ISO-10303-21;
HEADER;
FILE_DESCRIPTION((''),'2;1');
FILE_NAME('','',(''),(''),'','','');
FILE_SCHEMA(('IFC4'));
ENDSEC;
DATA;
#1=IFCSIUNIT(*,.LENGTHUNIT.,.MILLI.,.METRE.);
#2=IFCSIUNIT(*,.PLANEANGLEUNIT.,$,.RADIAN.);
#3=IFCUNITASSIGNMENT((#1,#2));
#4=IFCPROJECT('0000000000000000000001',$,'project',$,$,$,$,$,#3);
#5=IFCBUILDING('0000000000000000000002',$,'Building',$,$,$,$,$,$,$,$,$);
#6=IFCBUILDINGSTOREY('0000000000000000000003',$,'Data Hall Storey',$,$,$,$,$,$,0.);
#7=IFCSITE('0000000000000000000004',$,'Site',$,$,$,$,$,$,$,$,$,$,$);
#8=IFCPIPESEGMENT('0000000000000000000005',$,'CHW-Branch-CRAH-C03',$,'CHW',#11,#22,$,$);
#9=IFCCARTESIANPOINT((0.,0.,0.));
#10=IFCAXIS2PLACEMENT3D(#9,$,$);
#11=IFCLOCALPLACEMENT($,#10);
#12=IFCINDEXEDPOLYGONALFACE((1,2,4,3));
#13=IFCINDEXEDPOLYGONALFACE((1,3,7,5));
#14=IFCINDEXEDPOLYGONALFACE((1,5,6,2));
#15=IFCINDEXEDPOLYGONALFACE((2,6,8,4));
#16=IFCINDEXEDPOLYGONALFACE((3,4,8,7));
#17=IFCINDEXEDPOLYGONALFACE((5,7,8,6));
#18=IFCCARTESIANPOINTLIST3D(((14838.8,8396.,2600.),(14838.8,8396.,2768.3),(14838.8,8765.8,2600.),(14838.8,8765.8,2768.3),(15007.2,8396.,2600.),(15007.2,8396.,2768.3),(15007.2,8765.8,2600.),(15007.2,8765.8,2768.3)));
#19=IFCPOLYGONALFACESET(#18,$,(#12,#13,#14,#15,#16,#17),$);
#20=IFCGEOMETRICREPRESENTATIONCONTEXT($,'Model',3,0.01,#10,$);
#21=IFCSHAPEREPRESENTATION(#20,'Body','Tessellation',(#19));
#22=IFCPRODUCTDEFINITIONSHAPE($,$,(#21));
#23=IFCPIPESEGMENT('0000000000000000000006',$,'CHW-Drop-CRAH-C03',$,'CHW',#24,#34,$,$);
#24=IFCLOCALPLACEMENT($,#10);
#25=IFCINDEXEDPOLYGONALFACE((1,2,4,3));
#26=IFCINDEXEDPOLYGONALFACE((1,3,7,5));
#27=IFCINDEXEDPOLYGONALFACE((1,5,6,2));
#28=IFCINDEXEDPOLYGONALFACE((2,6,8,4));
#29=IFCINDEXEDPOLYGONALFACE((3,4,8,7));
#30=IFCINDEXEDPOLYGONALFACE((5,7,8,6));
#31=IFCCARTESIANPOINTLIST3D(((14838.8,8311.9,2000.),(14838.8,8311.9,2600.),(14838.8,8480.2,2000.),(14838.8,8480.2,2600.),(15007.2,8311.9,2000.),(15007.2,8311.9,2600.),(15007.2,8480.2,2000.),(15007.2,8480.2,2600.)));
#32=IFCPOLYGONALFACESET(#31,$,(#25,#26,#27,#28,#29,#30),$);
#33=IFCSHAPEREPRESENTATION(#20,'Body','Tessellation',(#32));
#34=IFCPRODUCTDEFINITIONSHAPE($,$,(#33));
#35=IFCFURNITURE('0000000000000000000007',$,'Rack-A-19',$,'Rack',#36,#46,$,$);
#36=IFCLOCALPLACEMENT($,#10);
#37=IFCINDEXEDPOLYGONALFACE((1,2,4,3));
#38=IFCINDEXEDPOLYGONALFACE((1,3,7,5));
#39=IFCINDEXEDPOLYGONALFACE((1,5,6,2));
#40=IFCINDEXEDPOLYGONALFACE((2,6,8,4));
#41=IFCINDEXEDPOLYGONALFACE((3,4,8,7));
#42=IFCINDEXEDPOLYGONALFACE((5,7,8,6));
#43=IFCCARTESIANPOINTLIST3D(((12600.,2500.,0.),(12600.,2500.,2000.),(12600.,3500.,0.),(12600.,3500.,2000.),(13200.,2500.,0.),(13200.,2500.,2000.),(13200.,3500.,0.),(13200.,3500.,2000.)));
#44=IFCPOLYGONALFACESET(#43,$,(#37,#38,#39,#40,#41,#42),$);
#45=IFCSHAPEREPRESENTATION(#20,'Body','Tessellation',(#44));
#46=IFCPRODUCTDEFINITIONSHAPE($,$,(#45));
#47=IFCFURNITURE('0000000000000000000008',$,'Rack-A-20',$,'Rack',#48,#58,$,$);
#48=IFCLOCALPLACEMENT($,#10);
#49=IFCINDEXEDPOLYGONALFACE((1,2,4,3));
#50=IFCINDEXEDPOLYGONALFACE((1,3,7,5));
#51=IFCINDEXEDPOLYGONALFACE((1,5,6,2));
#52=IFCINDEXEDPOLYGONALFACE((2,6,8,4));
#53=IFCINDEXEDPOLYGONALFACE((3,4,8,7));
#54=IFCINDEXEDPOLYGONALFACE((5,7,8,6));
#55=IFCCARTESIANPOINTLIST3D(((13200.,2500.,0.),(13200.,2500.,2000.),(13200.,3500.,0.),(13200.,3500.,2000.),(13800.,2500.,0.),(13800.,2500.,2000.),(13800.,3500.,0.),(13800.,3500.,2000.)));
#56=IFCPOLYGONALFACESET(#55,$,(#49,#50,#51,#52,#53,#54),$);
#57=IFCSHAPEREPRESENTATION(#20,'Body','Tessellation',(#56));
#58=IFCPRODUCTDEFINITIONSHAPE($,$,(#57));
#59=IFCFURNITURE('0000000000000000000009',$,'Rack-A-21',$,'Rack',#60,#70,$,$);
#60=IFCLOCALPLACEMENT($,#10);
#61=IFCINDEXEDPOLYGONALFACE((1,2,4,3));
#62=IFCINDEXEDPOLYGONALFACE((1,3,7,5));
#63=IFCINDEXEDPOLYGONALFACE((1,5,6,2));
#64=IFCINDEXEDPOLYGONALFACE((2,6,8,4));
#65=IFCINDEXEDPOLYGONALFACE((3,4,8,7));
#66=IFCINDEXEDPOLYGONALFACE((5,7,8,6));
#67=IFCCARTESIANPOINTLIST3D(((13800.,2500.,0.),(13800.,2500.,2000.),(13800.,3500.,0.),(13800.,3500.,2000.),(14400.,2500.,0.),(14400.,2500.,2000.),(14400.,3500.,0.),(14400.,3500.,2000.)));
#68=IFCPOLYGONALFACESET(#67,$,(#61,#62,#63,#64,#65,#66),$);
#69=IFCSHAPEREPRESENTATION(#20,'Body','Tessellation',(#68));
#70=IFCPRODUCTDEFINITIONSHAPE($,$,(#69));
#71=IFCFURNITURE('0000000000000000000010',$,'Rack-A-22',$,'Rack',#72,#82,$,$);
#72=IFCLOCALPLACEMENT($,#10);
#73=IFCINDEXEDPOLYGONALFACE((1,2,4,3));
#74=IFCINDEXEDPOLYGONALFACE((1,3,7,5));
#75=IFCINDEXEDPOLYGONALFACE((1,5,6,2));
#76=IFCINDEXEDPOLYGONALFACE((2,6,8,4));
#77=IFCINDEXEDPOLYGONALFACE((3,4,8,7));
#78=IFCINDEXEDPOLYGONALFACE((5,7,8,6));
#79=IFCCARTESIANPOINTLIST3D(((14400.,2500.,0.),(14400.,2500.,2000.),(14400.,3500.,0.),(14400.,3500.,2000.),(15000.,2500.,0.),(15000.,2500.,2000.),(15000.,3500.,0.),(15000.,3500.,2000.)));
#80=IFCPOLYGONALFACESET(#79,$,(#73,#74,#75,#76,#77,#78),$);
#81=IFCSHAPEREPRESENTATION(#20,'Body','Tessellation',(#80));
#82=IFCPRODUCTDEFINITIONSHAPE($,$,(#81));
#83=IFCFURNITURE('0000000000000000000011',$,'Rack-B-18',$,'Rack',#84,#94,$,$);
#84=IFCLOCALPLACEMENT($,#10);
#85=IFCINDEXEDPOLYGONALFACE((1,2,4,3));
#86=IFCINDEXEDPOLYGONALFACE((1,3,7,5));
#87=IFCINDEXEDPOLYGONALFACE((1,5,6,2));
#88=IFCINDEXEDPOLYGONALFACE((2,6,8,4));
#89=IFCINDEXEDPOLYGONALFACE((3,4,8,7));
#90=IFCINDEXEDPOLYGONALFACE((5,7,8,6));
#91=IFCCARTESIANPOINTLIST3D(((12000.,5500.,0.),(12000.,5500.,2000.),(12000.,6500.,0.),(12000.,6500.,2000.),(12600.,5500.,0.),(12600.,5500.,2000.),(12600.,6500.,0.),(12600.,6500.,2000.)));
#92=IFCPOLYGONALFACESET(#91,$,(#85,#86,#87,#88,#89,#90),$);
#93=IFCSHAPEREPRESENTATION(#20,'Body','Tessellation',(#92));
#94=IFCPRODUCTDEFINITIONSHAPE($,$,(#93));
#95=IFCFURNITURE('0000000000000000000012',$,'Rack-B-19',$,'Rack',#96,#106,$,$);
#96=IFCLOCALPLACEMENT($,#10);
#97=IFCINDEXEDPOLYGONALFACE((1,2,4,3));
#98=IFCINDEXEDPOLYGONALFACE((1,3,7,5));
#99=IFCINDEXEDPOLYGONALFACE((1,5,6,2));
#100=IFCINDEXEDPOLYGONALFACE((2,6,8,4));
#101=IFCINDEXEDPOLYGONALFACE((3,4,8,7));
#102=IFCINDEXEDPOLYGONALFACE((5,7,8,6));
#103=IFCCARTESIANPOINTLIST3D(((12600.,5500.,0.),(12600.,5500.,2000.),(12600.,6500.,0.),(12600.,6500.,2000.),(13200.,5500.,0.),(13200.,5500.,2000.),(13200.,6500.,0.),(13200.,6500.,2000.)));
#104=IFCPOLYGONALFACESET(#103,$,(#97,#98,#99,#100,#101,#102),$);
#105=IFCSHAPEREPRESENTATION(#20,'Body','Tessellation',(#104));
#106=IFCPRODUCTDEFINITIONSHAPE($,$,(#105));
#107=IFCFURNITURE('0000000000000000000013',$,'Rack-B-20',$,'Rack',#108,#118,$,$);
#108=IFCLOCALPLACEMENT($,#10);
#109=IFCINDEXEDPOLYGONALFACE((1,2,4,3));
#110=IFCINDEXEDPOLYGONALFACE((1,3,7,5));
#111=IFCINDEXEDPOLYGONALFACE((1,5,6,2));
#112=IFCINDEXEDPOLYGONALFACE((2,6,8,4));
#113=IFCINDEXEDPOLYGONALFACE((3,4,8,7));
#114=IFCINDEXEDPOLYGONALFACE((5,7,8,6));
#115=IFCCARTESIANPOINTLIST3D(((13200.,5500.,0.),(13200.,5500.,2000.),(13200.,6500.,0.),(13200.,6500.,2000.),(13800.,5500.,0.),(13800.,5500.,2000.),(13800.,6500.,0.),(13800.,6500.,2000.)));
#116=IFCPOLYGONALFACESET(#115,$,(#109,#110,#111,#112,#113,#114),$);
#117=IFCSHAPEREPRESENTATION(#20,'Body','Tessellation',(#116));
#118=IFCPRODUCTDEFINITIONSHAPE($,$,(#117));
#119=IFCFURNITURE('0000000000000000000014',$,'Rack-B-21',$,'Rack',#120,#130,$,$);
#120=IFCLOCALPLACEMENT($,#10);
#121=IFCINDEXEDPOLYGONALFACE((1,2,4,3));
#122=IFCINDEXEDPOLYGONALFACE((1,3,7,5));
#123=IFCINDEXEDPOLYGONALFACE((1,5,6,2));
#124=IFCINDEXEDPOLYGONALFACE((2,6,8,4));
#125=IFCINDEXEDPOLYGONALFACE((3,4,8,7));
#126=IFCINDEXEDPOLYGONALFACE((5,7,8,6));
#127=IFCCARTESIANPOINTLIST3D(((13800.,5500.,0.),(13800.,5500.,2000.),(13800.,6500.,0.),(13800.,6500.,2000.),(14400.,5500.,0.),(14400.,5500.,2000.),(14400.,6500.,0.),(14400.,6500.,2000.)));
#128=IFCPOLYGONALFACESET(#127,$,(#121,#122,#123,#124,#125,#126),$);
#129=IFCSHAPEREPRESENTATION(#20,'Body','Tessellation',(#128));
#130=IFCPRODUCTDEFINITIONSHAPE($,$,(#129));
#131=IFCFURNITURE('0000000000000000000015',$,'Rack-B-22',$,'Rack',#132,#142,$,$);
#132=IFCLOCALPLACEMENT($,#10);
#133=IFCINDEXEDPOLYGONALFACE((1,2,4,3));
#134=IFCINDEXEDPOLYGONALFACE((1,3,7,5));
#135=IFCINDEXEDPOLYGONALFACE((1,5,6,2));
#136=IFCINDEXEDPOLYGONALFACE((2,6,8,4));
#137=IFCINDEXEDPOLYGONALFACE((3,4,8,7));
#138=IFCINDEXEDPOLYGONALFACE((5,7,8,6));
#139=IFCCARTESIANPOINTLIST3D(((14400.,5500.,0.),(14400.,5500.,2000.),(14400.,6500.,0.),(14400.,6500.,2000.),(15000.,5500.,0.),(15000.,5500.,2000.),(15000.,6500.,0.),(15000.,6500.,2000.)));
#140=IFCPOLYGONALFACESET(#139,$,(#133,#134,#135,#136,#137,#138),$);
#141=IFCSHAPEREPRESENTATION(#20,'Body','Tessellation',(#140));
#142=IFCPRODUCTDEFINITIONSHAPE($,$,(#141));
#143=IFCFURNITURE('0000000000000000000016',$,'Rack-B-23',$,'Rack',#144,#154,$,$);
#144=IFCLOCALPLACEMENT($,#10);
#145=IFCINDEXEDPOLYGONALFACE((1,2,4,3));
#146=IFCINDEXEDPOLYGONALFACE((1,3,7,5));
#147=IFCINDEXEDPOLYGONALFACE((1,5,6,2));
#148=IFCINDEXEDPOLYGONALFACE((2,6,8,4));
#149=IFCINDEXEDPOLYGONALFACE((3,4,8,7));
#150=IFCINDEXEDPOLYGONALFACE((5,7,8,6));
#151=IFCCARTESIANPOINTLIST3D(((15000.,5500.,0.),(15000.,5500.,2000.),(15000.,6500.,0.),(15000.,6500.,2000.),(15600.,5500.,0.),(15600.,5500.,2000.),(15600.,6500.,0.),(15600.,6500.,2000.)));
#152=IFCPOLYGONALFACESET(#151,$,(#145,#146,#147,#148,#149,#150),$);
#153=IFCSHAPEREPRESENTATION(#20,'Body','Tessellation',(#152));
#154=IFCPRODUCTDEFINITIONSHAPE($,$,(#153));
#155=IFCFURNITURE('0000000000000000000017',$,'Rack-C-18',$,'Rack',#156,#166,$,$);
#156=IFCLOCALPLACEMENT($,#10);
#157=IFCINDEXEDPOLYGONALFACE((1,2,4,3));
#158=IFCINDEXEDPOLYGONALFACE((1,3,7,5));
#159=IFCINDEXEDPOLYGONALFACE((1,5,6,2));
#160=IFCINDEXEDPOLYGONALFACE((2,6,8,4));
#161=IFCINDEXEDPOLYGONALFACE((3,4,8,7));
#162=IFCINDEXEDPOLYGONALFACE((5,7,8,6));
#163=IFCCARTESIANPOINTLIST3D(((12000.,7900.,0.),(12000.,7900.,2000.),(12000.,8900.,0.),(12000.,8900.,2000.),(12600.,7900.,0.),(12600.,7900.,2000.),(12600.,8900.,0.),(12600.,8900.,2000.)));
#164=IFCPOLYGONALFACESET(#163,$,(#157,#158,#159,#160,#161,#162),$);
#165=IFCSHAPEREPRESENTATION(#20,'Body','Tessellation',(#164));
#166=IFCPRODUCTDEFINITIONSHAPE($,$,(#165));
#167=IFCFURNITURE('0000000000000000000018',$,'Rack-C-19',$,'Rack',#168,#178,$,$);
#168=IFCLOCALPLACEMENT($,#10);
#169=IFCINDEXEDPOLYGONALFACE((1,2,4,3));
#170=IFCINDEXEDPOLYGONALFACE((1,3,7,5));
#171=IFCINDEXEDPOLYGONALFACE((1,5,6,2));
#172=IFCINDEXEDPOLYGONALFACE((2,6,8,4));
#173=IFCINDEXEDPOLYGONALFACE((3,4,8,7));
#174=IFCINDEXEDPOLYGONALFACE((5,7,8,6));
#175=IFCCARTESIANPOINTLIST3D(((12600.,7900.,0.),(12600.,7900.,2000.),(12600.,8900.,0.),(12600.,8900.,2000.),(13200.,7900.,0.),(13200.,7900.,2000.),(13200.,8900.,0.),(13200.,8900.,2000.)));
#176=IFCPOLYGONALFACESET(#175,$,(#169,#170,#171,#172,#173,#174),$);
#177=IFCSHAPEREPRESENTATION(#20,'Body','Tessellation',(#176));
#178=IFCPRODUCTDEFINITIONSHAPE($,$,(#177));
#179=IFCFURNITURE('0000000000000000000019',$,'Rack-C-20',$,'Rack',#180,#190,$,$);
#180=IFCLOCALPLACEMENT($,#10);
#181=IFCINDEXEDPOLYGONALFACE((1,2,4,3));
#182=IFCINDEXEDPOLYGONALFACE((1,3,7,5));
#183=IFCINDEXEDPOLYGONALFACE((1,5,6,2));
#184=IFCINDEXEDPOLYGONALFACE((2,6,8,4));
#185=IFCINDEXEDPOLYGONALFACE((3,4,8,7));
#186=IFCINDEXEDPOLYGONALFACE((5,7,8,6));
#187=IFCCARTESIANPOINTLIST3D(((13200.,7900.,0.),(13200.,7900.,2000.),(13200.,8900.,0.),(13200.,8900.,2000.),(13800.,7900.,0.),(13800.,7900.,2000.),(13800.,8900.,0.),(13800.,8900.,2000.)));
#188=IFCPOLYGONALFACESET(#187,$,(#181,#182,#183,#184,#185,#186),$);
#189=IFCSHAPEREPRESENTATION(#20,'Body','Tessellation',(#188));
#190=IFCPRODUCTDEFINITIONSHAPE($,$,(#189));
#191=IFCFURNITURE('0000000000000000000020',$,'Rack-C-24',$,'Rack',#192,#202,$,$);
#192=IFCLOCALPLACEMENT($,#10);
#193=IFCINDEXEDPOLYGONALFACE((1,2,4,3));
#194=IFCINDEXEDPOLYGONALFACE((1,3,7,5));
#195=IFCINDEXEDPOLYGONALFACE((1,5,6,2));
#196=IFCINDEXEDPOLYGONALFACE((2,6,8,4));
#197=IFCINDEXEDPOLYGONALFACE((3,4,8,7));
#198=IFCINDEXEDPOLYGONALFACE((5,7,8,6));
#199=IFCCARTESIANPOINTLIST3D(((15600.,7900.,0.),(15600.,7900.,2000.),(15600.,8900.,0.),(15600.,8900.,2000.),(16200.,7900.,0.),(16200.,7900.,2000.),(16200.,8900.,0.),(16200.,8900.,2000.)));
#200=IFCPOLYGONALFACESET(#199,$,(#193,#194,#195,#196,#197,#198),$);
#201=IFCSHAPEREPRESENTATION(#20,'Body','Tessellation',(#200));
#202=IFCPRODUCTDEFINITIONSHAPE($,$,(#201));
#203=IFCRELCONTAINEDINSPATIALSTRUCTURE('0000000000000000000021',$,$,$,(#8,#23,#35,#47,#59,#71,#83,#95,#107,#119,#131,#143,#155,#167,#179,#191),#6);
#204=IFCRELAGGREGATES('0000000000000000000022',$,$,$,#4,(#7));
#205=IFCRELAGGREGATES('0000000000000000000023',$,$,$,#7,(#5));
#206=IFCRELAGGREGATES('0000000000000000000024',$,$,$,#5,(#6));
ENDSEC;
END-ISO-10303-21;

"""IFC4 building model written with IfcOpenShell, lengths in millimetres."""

from ifc_helpers import new_model, si_unit, frame, origin, place, context, project, spatial, rectangle, extrude, element, save


model = new_model("IFC4")

# Units and contexts
model_context = context("Model", 3, precision=0.01, world=origin())
ifc_project = project(units=[si_unit("LENGTHUNIT", "METRE", prefix="MILLI"), si_unit("PLANEANGLEUNIT", "RADIAN")])

# Site, building, storey
site = spatial("IfcSite", under=ifc_project, Name="Site")
building = spatial("IfcBuilding", under=site, Name="Building")
storey = spatial("IfcBuildingStorey", under=building, Name="Data Hall Storey", Elevation=0.0)

# Pipe segments
pipe_segment_1_placement = place(None, frame((14923.0, 8580.9, 2600.0)))
element("IfcPipeSegment", 1, at=pipe_segment_1_placement, inside=storey, Name="CHW-Branch-CRAH-C03", ObjectType="CHW", context=model_context, shape_type="SweptSolid", body=[
    extrude(rectangle(XDim=168.3, YDim=369.9), origin(), (0.0, 0.0, 1.0), 168.3),
])
pipe_segment_2_placement = place(None, frame((14923.0, 8396.0, 2000.0)))
element("IfcPipeSegment", 2, at=pipe_segment_2_placement, inside=storey, Name="CHW-Drop-CRAH-C03", ObjectType="CHW", context=model_context, shape_type="SweptSolid", body=[
    extrude(rectangle(XDim=168.3, YDim=168.3), origin(), (0.0, 0.0, 1.0), 600.0),
])

# Furniture
for number, where, name in (
    (3, (12900.0, 3000.0, 0.0), "Rack-A-19"),
    (4, (13500.0, 3000.0, 0.0), "Rack-A-20"),
    (5, (14100.0, 3000.0, 0.0), "Rack-A-21"),
    (6, (14700.0, 3000.0, 0.0), "Rack-A-22"),
    (7, (12300.0, 6000.0, 0.0), "Rack-B-18"),
    (8, (12900.0, 6000.0, 0.0), "Rack-B-19"),
    (9, (13500.0, 6000.0, 0.0), "Rack-B-20"),
    (10, (14100.0, 6000.0, 0.0), "Rack-B-21"),
    (11, (14700.0, 6000.0, 0.0), "Rack-B-22"),
    (12, (15300.0, 6000.0, 0.0), "Rack-B-23"),
    (13, (12300.0, 8400.0, 0.0), "Rack-C-18"),
    (14, (12900.0, 8400.0, 0.0), "Rack-C-19"),
    (15, (13500.0, 8400.0, 0.0), "Rack-C-20"),
    (16, (15900.0, 8400.0, 0.0), "Rack-C-24"),
):
    element("IfcFurniture", number, at=place(None, frame(where)), inside=storey, Name=name, ObjectType="Rack", context=model_context, shape_type="SweptSolid", body=[
        extrude(rectangle(XDim=600.0, YDim=1000.0), origin(), (0.0, 0.0, 1.0), 2000.0),
    ])

save(model, "model.ifc")
